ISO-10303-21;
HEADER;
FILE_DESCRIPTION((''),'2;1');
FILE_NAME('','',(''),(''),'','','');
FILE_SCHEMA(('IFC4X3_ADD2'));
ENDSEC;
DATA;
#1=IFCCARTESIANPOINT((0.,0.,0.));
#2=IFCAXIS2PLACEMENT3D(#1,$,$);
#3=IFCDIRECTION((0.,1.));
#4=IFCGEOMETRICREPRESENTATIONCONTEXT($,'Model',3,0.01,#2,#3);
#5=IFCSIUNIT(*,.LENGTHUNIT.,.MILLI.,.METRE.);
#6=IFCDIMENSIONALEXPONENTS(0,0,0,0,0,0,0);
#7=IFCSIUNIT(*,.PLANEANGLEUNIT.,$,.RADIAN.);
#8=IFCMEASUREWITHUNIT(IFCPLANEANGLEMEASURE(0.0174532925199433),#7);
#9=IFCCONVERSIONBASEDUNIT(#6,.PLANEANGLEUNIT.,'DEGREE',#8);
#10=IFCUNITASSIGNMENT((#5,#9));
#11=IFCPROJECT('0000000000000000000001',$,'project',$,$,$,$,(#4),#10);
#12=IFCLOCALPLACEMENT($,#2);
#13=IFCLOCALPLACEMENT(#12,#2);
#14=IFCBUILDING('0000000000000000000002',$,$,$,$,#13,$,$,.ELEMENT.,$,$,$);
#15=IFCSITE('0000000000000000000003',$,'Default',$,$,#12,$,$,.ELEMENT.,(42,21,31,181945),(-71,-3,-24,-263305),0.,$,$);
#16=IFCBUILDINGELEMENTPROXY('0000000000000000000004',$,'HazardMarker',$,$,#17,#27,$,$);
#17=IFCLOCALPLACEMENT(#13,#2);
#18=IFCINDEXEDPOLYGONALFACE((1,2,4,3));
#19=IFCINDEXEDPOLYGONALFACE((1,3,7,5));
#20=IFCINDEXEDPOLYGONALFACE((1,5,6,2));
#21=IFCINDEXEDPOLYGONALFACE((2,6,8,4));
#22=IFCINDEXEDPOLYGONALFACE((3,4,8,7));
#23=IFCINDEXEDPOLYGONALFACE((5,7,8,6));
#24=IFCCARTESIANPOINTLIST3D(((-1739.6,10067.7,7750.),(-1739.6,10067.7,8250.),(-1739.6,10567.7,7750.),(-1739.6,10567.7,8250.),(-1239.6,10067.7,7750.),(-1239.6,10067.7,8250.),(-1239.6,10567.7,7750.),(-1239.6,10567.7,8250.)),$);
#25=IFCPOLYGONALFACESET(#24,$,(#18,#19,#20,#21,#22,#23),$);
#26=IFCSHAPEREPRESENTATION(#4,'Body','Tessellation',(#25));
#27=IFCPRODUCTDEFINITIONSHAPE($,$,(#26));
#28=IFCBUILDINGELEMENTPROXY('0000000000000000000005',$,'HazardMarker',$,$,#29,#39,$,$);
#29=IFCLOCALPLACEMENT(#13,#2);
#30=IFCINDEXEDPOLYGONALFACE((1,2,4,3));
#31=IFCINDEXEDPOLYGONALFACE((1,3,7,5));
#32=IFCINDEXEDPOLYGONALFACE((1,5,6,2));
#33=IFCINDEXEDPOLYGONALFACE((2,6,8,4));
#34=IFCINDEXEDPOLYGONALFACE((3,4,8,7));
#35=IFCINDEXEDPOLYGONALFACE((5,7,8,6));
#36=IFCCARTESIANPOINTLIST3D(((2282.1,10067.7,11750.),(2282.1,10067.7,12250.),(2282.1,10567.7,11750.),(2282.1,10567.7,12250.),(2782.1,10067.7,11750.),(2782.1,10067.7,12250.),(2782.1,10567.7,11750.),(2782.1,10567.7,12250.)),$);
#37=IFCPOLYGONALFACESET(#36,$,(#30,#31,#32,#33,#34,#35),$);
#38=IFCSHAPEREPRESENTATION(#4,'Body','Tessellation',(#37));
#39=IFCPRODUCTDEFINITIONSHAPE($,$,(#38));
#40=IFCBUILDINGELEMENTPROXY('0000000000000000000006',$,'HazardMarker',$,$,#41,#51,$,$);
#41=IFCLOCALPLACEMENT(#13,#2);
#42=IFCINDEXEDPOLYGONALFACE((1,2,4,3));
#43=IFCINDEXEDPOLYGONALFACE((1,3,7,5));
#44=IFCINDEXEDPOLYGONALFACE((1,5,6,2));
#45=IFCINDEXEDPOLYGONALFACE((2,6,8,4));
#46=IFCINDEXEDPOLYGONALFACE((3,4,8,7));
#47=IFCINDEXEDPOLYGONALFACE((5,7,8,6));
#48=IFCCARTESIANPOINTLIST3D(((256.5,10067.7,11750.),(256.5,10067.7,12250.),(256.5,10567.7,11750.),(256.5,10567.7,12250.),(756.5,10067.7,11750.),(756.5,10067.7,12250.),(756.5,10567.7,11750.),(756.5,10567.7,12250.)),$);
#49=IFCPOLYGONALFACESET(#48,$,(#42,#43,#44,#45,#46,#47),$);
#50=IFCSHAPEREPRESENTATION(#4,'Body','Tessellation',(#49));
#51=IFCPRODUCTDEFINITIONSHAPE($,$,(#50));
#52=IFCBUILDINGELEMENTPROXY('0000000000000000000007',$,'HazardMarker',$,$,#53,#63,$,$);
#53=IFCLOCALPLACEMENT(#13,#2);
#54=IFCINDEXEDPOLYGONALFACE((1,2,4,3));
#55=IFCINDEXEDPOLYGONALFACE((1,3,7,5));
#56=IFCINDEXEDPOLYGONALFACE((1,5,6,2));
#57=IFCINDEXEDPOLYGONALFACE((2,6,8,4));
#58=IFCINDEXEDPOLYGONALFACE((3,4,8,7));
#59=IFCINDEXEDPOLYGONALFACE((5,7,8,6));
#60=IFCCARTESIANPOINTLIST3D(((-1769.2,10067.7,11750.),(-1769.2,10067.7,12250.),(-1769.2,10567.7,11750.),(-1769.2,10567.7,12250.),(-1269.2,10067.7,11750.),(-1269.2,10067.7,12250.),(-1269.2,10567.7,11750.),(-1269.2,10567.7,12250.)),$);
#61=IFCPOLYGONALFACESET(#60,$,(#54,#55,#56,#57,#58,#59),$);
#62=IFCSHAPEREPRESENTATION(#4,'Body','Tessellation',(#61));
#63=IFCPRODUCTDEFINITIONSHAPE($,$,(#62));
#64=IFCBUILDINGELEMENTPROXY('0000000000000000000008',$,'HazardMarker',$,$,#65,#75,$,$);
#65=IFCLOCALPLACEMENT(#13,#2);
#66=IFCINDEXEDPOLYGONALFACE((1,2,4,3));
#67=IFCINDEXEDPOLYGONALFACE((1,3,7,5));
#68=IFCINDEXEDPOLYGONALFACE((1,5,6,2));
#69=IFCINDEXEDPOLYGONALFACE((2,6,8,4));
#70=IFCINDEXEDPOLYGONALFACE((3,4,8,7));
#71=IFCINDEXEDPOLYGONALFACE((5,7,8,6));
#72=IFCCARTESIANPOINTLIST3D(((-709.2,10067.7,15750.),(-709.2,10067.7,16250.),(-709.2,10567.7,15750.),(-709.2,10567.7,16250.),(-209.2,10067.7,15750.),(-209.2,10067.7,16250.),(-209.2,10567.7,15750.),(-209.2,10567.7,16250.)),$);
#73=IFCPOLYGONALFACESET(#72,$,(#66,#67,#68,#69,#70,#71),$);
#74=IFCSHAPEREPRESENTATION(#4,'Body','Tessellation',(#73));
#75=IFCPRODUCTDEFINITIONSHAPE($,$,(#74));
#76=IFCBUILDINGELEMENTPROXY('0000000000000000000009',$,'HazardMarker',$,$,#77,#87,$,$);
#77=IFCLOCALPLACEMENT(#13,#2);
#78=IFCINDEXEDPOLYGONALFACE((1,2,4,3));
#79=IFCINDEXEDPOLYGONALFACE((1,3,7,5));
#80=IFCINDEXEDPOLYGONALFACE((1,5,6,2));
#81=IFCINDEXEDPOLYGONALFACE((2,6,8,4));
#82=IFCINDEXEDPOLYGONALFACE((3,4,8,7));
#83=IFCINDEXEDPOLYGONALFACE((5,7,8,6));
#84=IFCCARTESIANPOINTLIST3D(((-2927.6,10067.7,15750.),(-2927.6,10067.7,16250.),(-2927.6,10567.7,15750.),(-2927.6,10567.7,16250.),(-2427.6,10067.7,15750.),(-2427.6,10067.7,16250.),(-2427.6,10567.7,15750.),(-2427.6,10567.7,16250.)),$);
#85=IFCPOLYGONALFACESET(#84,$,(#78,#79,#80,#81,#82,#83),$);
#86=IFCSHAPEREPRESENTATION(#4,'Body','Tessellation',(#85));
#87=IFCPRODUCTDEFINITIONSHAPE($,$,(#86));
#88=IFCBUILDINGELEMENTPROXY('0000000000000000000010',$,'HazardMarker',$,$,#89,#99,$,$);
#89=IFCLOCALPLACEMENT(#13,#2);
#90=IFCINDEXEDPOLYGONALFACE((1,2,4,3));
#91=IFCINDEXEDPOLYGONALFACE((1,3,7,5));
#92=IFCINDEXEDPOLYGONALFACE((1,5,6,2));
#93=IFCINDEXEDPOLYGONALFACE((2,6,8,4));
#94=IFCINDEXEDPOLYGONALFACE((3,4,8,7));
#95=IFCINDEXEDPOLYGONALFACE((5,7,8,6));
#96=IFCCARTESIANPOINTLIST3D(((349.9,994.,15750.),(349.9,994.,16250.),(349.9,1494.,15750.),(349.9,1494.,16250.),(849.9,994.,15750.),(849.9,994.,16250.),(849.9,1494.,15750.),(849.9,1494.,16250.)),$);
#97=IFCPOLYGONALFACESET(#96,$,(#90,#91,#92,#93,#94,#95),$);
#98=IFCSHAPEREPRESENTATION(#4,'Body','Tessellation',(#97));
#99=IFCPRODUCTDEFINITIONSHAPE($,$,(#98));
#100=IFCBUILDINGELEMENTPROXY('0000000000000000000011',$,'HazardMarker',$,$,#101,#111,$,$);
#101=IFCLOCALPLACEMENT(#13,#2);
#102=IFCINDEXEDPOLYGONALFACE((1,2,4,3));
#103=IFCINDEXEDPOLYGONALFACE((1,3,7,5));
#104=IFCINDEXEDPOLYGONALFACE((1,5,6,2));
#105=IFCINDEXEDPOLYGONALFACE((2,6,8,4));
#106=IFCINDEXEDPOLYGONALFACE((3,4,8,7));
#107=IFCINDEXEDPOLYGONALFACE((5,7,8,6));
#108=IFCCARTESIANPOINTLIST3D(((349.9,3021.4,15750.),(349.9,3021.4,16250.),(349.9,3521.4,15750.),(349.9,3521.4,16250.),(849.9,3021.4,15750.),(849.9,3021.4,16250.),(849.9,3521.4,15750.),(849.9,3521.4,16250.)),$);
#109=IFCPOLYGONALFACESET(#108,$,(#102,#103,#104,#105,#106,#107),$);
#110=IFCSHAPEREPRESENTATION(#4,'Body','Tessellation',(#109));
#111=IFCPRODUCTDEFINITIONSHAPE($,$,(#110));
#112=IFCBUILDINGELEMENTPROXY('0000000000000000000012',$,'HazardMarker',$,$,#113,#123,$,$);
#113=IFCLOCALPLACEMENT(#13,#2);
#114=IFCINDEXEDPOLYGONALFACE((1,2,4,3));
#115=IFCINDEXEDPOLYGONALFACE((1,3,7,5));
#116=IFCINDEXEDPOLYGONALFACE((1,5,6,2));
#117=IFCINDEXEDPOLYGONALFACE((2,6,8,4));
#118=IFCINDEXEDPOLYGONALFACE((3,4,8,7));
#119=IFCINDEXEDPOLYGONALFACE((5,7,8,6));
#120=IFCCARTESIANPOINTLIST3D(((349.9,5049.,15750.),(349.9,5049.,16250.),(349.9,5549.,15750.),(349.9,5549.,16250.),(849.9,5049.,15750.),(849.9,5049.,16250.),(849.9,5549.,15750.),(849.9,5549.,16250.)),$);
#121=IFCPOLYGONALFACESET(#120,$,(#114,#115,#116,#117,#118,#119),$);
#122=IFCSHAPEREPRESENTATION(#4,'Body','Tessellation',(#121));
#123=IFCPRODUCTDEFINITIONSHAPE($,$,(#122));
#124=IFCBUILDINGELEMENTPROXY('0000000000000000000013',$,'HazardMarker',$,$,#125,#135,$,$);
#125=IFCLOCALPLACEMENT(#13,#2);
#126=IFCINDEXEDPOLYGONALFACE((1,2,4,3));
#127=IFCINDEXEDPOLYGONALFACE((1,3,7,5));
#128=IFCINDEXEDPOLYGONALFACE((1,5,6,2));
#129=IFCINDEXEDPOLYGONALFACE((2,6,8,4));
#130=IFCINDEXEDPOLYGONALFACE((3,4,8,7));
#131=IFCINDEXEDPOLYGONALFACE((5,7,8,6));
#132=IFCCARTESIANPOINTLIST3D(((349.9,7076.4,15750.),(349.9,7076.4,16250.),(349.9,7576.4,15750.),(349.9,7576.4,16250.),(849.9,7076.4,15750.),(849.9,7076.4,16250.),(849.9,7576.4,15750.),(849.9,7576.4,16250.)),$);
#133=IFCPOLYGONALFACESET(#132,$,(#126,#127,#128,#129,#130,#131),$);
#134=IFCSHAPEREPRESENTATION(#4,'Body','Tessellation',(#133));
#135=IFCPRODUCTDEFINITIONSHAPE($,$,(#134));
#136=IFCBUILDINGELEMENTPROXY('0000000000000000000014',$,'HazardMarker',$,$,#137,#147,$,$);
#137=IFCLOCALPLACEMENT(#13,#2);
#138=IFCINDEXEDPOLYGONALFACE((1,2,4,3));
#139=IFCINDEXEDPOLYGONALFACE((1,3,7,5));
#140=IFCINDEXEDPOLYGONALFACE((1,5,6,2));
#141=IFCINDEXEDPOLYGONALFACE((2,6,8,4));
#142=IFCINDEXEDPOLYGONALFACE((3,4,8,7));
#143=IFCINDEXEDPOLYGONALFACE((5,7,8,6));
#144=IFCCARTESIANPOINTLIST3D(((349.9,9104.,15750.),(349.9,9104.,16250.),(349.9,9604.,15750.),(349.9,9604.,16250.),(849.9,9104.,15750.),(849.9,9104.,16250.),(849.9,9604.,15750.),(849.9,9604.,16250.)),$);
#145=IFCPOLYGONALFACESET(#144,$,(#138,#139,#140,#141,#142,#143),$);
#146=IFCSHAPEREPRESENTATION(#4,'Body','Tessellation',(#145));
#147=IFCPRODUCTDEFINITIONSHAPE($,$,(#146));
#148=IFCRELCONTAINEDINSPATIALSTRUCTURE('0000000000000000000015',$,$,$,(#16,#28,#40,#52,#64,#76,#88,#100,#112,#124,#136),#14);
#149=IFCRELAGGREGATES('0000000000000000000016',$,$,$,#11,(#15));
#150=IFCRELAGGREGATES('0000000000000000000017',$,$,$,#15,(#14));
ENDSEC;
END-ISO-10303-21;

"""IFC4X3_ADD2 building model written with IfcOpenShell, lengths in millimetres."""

from ifc_helpers import new_model, entity, si_unit, converted_unit, direction, frame, origin, place, context, project, spatial, rectangle, extrude, element, save


model = new_model("IFC4X3_ADD2")

# Units and contexts
model_context = context("Model", 3, precision=0.01, world=origin(), true_north=direction((0.0, 1.0)))
ifc_project = project(units=[si_unit("LENGTHUNIT", "METRE", prefix="MILLI"), converted_unit("PLANEANGLEUNIT", "DEGREE", entity("IfcPlaneAngleMeasure", 0.0174532925199433), si_unit("PLANEANGLEUNIT", "RADIAN"), dimensions=[0, 0, 0, 0, 0, 0, 0])], contexts=[model_context])

# Site, building
site_placement = place(None, origin())
site = spatial("IfcSite", under=ifc_project, at=site_placement, Name="Default", CompositionType="ELEMENT", RefLatitude=(42, 21, 31, 181945), RefLongitude=(-71, -3, -24, -263305), RefElevation=0.0)
building_placement = place(site_placement, origin())
building = spatial("IfcBuilding", under=site, at=building_placement, CompositionType="ELEMENT")

# Building element proxies
for number, where, name in (
    (1, (-1489.6, 10317.7, 8000.0), "HazardMarker"),
    (2, (2532.1, 10317.7, 12000.0), "HazardMarker"),
    (3, (506.5, 10317.7, 12000.0), "HazardMarker"),
    (4, (-1519.2, 10317.7, 12000.0), "HazardMarker"),
    (5, (-459.2, 10317.7, 16000.0), "HazardMarker"),
    (6, (-2677.6, 10317.7, 16000.0), "HazardMarker"),
    (7, (599.9, 1244.0, 16000.0), "HazardMarker"),
    (8, (599.9, 3271.4, 16000.0), "HazardMarker"),
    (9, (599.9, 5298.9, 16000.0), "HazardMarker"),
    (10, (599.9, 7326.4, 16000.0), "HazardMarker"),
    (11, (599.9, 9354.0, 16000.0), "HazardMarker"),
):
    element("IfcBuildingElementProxy", number, at=place(None, frame(where)), inside=building, Name=name, context=model_context, shape_type="SweptSolid", body=[
        extrude(rectangle(XDim=500.0, YDim=500.0), frame((0.0, 0.0, -250.0)), (0.0, 0.0, 1.0), 500.0),
    ])

save(model, "model.ifc")
